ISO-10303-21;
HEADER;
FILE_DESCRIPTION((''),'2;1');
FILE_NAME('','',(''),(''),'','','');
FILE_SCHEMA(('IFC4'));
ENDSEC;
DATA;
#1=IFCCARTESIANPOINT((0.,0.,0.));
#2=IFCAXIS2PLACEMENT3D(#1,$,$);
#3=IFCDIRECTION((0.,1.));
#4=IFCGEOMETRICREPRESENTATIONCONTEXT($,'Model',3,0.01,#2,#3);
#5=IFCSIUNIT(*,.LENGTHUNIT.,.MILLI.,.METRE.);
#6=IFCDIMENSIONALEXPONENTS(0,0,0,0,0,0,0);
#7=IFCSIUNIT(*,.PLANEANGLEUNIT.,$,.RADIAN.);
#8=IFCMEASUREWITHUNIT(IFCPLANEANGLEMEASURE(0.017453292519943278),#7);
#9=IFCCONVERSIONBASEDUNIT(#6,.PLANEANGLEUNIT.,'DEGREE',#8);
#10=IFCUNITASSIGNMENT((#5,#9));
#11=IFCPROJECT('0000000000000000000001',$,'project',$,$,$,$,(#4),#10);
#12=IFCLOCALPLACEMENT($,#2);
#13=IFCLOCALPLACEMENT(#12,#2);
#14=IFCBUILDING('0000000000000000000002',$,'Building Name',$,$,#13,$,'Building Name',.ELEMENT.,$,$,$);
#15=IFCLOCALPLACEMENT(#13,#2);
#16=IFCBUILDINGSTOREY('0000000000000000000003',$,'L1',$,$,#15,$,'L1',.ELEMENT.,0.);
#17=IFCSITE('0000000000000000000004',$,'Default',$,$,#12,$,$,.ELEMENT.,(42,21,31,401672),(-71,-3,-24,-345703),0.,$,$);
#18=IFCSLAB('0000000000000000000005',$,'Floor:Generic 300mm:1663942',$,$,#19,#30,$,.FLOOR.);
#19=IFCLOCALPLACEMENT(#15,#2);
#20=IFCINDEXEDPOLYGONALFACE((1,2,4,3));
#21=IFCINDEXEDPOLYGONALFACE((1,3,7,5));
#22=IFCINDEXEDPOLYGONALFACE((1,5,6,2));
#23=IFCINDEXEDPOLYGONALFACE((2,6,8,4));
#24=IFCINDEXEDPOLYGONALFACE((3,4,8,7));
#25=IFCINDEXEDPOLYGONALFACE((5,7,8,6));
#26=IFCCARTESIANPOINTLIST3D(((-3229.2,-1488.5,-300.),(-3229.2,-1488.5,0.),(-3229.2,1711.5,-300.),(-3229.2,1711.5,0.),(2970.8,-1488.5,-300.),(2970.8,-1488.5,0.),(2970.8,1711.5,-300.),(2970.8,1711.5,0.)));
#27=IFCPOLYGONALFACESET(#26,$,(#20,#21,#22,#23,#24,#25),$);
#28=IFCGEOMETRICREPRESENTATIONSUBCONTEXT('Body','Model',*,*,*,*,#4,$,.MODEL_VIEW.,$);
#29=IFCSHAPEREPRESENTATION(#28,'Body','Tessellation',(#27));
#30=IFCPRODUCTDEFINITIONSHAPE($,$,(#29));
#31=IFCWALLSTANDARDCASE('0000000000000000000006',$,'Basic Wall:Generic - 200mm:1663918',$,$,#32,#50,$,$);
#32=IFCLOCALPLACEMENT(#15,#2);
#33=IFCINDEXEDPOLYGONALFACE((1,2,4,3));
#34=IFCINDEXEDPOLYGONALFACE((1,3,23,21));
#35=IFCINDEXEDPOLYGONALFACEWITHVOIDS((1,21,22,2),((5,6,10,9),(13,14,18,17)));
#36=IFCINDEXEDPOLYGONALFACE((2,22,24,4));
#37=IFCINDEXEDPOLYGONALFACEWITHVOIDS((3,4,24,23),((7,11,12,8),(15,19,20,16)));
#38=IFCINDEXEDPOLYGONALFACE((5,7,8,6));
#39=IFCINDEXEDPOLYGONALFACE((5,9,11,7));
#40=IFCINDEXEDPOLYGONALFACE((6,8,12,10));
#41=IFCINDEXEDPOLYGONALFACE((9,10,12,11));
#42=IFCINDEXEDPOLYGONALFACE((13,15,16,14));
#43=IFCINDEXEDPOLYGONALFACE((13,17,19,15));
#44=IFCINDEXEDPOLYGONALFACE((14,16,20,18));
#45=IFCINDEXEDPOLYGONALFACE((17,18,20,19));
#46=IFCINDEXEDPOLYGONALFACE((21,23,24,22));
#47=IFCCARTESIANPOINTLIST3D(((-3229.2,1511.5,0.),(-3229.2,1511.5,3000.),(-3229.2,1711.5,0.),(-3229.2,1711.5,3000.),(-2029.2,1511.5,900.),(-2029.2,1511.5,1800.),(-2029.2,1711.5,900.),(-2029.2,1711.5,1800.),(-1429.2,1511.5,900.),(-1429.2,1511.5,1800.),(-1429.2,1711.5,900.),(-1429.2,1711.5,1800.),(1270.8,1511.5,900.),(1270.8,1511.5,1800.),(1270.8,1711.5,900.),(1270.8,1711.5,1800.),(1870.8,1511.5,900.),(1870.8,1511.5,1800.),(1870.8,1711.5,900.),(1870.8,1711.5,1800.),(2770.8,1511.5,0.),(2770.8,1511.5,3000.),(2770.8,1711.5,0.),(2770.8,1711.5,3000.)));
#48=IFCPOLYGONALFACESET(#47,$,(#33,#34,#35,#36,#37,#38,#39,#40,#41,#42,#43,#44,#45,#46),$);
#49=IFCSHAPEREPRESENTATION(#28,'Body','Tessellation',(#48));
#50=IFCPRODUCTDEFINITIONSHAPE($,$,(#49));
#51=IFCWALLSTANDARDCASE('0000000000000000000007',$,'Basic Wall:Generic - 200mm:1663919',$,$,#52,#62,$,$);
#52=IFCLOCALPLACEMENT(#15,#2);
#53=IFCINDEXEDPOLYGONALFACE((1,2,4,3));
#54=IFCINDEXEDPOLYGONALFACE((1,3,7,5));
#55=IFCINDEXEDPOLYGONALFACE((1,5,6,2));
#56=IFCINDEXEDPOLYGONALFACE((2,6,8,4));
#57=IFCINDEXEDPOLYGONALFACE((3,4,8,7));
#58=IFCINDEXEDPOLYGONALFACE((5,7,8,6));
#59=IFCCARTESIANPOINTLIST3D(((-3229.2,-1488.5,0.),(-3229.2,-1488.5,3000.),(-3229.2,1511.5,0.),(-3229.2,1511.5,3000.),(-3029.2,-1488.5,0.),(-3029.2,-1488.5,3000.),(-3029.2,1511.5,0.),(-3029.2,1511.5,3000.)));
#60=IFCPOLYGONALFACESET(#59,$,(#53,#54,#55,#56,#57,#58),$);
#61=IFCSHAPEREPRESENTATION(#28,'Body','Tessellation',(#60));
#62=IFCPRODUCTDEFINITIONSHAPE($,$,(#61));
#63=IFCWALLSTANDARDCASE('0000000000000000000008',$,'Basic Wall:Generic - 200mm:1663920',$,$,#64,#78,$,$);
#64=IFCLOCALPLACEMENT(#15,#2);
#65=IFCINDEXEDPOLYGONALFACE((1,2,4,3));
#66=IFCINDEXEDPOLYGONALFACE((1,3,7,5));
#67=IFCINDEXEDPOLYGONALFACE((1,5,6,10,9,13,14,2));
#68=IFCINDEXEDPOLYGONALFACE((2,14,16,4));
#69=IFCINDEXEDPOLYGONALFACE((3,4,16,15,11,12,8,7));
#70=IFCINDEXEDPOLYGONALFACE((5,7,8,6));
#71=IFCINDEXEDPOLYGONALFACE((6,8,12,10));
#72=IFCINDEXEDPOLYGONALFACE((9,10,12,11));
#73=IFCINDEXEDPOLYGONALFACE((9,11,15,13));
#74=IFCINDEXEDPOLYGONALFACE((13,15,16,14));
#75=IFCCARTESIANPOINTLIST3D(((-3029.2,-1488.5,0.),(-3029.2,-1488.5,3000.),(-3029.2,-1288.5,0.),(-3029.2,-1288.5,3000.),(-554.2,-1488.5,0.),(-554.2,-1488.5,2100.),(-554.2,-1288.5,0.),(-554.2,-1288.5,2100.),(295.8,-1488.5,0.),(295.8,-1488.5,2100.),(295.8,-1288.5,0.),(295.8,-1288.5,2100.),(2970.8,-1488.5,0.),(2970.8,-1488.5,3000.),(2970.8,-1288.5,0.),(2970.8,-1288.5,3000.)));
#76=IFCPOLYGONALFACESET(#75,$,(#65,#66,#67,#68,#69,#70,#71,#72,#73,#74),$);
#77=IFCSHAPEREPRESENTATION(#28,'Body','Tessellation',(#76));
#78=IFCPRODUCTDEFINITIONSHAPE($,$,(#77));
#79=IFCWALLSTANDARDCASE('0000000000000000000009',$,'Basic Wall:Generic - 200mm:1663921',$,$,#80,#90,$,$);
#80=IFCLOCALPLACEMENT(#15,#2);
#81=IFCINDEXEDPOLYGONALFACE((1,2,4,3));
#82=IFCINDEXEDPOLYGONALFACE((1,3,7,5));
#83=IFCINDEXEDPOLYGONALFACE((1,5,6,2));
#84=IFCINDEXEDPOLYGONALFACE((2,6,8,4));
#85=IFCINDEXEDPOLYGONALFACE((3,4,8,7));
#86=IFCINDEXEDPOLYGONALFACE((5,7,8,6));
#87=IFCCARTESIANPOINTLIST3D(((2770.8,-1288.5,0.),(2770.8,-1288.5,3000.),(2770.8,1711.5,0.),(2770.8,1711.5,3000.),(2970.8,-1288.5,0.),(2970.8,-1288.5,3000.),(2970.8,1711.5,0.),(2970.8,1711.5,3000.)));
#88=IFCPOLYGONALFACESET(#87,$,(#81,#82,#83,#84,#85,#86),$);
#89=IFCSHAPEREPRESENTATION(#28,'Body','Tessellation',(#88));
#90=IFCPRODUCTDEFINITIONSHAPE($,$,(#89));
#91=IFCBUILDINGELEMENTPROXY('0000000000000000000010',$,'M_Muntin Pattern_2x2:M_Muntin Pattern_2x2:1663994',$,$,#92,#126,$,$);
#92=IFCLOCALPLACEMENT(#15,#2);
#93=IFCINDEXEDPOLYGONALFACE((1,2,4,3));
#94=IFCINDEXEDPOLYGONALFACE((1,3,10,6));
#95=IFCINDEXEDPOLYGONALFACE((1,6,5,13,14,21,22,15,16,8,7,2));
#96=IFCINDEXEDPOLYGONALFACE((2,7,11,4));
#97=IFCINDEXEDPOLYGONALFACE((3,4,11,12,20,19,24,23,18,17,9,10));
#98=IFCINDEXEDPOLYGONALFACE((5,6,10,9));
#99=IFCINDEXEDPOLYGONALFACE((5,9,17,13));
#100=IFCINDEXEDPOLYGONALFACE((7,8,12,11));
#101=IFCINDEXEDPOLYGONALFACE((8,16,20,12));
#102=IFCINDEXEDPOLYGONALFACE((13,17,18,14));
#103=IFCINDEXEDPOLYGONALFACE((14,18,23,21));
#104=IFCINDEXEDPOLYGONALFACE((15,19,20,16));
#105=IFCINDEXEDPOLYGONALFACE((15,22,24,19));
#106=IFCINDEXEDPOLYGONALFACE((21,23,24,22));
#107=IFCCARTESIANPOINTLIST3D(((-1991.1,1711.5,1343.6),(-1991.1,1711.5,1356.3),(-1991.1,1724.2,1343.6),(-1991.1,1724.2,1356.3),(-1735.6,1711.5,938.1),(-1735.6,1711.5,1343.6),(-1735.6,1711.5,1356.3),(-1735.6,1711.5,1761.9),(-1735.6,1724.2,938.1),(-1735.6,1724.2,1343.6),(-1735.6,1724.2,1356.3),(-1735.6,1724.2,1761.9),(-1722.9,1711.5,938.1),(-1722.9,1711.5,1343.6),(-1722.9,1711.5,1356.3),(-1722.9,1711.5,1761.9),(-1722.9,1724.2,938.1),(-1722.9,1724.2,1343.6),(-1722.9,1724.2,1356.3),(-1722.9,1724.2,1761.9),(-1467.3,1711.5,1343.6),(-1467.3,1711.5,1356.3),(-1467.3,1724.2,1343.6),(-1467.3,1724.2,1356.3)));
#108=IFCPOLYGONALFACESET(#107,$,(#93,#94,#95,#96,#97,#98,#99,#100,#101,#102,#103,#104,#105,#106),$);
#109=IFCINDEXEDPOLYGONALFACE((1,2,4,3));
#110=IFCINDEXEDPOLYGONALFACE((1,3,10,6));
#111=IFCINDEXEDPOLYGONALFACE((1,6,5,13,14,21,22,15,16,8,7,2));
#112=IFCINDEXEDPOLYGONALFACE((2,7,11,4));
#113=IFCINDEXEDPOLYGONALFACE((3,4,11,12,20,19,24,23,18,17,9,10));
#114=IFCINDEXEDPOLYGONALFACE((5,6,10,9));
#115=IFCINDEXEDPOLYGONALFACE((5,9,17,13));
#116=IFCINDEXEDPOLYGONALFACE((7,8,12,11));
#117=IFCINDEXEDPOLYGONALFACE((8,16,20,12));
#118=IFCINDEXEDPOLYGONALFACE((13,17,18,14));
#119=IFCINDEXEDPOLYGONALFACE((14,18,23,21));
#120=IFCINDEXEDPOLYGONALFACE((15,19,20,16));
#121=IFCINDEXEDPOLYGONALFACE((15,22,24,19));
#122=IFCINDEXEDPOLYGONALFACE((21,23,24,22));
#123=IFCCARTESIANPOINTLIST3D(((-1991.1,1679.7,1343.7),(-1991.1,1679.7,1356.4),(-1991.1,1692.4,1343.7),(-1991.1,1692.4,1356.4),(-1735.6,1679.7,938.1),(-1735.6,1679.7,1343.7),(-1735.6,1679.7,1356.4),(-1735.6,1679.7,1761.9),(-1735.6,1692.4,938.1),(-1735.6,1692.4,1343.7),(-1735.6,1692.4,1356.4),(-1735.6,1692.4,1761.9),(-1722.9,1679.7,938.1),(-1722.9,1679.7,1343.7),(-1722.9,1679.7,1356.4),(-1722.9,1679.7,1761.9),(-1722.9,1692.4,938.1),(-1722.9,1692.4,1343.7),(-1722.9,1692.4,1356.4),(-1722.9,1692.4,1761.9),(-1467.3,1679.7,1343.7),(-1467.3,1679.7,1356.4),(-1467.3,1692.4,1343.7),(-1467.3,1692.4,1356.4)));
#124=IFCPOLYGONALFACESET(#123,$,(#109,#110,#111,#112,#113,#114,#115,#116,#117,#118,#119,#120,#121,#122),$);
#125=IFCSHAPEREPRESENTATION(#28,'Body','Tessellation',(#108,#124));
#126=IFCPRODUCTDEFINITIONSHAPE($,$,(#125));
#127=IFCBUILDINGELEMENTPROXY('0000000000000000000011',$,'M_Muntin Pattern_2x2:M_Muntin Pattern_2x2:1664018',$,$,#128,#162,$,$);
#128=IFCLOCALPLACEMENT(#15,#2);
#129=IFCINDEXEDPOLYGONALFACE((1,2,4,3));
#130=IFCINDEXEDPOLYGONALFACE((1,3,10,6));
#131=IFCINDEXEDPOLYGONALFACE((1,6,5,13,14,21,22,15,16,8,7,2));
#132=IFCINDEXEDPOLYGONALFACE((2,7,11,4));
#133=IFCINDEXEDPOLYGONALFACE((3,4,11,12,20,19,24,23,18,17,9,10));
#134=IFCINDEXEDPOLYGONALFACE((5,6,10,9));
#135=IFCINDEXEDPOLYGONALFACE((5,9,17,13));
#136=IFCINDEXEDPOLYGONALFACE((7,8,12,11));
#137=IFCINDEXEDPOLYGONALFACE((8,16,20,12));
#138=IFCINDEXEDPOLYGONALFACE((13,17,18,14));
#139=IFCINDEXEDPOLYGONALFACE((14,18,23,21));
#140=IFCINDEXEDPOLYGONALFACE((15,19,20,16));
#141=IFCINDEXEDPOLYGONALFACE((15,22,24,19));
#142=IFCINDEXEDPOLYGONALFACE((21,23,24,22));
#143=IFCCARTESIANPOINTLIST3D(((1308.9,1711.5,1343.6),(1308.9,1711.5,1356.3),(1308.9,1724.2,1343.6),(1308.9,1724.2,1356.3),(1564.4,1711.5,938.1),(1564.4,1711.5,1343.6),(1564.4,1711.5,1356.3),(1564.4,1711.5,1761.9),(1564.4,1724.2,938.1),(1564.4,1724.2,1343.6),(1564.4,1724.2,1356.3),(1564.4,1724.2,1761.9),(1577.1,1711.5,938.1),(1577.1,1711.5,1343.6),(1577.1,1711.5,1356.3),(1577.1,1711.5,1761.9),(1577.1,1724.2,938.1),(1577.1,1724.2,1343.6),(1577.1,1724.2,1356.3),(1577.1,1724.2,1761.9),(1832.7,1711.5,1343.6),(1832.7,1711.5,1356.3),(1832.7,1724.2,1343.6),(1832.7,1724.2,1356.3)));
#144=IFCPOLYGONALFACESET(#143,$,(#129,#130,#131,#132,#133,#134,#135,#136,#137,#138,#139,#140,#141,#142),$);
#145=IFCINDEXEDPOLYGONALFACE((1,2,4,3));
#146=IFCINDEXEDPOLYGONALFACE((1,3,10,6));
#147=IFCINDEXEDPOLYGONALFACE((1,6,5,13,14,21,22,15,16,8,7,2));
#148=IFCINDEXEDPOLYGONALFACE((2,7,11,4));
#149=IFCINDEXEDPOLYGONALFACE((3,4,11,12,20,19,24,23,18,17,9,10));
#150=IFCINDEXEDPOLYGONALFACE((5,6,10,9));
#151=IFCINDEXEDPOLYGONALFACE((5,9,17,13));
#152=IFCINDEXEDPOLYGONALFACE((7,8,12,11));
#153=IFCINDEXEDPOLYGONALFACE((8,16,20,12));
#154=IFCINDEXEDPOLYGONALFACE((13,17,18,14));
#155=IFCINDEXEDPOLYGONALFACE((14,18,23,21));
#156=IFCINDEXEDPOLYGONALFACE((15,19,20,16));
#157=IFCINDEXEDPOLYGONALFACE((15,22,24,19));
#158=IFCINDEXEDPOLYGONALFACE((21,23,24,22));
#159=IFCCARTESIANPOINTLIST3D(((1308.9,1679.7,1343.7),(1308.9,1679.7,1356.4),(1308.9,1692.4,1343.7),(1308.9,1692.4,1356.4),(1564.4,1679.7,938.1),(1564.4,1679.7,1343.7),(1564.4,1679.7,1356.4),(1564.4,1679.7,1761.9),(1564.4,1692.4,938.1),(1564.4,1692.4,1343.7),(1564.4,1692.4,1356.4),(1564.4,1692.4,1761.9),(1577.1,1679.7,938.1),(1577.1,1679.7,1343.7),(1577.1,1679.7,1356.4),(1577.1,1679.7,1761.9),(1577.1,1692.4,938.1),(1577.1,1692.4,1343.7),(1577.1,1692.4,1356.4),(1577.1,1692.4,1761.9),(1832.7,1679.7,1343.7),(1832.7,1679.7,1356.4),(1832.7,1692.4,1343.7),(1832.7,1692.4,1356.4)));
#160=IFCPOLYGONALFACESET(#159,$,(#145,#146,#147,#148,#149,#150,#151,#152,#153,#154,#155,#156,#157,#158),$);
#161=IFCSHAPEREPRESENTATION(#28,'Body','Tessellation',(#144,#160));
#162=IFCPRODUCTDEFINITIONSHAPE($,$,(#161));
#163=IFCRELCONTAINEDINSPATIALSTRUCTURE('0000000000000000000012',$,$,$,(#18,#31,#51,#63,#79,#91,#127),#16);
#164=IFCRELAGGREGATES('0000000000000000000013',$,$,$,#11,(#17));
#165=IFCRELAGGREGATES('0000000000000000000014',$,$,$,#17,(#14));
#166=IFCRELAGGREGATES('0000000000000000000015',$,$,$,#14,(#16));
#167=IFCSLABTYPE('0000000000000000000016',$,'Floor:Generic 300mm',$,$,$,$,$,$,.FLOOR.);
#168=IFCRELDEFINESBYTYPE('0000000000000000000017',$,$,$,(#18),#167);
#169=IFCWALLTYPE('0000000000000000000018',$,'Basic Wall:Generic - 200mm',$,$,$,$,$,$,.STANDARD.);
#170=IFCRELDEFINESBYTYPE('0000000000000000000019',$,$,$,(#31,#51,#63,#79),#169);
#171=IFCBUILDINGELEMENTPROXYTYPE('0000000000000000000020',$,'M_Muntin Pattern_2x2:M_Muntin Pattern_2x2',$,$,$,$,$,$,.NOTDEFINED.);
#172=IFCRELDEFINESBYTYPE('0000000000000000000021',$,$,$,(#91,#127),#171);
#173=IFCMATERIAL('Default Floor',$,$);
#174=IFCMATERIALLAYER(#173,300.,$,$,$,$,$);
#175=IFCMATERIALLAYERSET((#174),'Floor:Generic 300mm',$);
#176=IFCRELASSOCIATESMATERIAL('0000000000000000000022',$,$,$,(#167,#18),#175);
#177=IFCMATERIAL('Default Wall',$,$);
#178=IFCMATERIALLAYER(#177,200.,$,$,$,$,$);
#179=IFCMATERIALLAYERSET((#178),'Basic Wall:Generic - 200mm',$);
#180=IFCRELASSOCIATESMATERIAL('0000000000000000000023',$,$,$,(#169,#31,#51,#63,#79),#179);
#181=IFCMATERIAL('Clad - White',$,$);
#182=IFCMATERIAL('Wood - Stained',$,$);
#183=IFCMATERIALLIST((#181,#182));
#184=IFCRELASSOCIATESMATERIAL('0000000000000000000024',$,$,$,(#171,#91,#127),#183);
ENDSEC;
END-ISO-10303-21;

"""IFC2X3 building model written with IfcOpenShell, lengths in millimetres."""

from ifc_helpers import new_model, entity, si_unit, converted_unit, direction, frame, frame_2d, origin, origin_2d_with_axis, place, context, subcontext, project, spatial, polyline, rectangle, outline, extrude, source, transform, mapped, material, material_list, layer, layer_set, layer_usage, type_object, type_shapes, element, save


model = new_model("IFC2X3")

# Units and contexts
model_context = context("Model", 3, precision=0.01, world=origin(), true_north=direction((0.0, 1.0)))
body_context = subcontext(model_context, "Body", "Model", "MODEL_VIEW")
ifc_project = project(units=[si_unit("LENGTHUNIT", "METRE", prefix="MILLI"), converted_unit("PLANEANGLEUNIT", "DEGREE", entity("IfcPlaneAngleMeasure", 0.017453292519943278), si_unit("PLANEANGLEUNIT", "RADIAN"), dimensions=[0, 0, 0, 0, 0, 0, 0])], contexts=[model_context])

# Site, building, storey
site_placement = place(None, origin())
site = spatial("IfcSite", under=ifc_project, at=site_placement, Name="Default", CompositionType="ELEMENT", RefLatitude=(42, 21, 31, 401672), RefLongitude=(-71, -3, -24, -345703), RefElevation=0.0)
building_placement = place(site_placement, origin())
building = spatial("IfcBuilding", under=site, at=building_placement, Name="Building Name", LongName="Building Name", CompositionType="ELEMENT")
storey_placement = place(building_placement, origin())
storey = spatial("IfcBuildingStorey", under=building, at=storey_placement, Name="L1", LongName="L1", CompositionType="ELEMENT", Elevation=0.0)

# Slab
ifc_material_1 = material(Name="Default Floor")
ifc_layer_1 = layer(ifc_material_1, 300.0)
ifc_layer_set_1 = layer_set([ifc_layer_1], Name="Floor:Generic 300mm")
ifc_layer_usage_1 = layer_usage(ifc_layer_set_1, "AXIS3", "POSITIVE", 0.0)
slab_type = type_object("IfcSlabType", Name="Floor:Generic 300mm", PredefinedType="FLOOR", material=ifc_layer_set_1)
slab_placement = place(storey_placement, origin())
element("IfcSlab", 1, at=slab_placement, inside=storey, type_object=slab_type, material=ifc_layer_usage_1, Name="Floor:Generic 300mm:1663942", PredefinedType="FLOOR", context=body_context, shape_type="SweptSolid", body=[
    extrude(rectangle(XDim=3200.0, YDim=6200.0, at=origin_2d_with_axis()), frame((-129.2, 111.5, 0.0), z_axis=(0.0, 0.0, -1.0), x_axis=(0.0, 1.0, 0.0)), (0.0, 0.0, 1.0), 300.0),
])

# Wall, openings
ifc_material_2 = material(Name="Default Wall")
ifc_layer_2 = layer(ifc_material_2, 200.0)
ifc_layer_set_2 = layer_set([ifc_layer_2], Name="Basic Wall:Generic - 200mm")
ifc_layer_usage_2 = layer_usage(ifc_layer_set_2, "AXIS2", "NEGATIVE", 100.0)
wall_type = type_object("IfcWallType", Name="Basic Wall:Generic - 200mm", PredefinedType="STANDARD", material=ifc_layer_set_2)
wall_1_placement = place(storey_placement, frame((-3229.2, 1611.5, 0.0)))
wall_1 = element("IfcWallStandardCase", 2, at=wall_1_placement, inside=storey, type_object=wall_type, material=ifc_layer_usage_2, Name="Basic Wall:Generic - 200mm:1663918", context=body_context, shape_type="SweptSolid", body=[
    extrude(rectangle(XDim=6000.0, YDim=200.0, at=frame_2d((3000.0, 0.0), x_axis=(-1.0, 0.0))), origin(), (0.0, 0.0, 1.0), 3000.0),
])
opening_1_placement = place(wall_1_placement, frame((1200.0, -100.0, 900.0)))
element("IfcOpeningElement", 3, at=opening_1_placement, cuts=wall_1, ObjectType="Opening", context=body_context, shape_type="SweptSolid", body=[
    extrude(rectangle(XDim=900.0, YDim=600.0, at=frame_2d((450.0, 300.0), x_axis=(-1.0, 0.0))), frame((0.0, 0.0, 0.0), z_axis=(0.0, 1.0, 0.0), x_axis=(0.0, 0.0, 1.0)), (0.0, 0.0, 1.0), 200.0),
])
opening_2_placement = place(wall_1_placement, frame((4500.0, -100.0, 900.0)))
element("IfcOpeningElement", 4, at=opening_2_placement, cuts=wall_1, ObjectType="Opening", context=body_context, shape_type="SweptSolid", body=[
    extrude(rectangle(XDim=900.0, YDim=600.0, at=frame_2d((450.0, 300.0), x_axis=(-1.0, 0.0))), frame((0.0, 0.0, 0.0), z_axis=(0.0, 1.0, 0.0), x_axis=(0.0, 0.0, 1.0)), (0.0, 0.0, 1.0), 200.0),
])

# Wall
ifc_layer_usage_3 = layer_usage(ifc_layer_set_2, "AXIS2", "NEGATIVE", 100.0)
wall_2_placement = place(storey_placement, frame((-3129.2, -1488.5, 0.0), z_axis=(0.0, 0.0, 1.0), x_axis=(0.0, 1.0, 0.0)))
element("IfcWallStandardCase", 5, at=wall_2_placement, inside=storey, type_object=wall_type, material=ifc_layer_usage_3, Name="Basic Wall:Generic - 200mm:1663919", context=body_context, shape_type="SweptSolid", body=[
    extrude(rectangle(XDim=3000.0, YDim=200.0, at=frame_2d((1500.0, 0.0), x_axis=(-1.0, 0.0))), origin(), (0.0, 0.0, 1.0), 3000.0),
])

# Wall, opening
ifc_layer_usage_4 = layer_usage(ifc_layer_set_2, "AXIS2", "NEGATIVE", 100.0)
wall_3_placement = place(storey_placement, frame((2970.8, -1388.5, 0.0), z_axis=(0.0, 0.0, 1.0), x_axis=(-1.0, 0.0, 0.0)))
wall_3 = element("IfcWallStandardCase", 6, at=wall_3_placement, inside=storey, type_object=wall_type, material=ifc_layer_usage_4, Name="Basic Wall:Generic - 200mm:1663920", context=body_context, shape_type="SweptSolid", body=[
    extrude(rectangle(XDim=6000.0, YDim=200.0, at=frame_2d((3000.0, 0.0), x_axis=(1.0, 0.0))), origin(), (0.0, 0.0, 1.0), 3000.0),
])
opening_3_placement = place(wall_3_placement, frame((2675.0, -100.0, 0.0)))
element("IfcOpeningElement", 7, at=opening_3_placement, cuts=wall_3, ObjectType="Opening", context=body_context, shape_type="SweptSolid", body=[
    extrude(rectangle(XDim=2100.0, YDim=850.0, at=frame_2d((1050.0, 425.0), x_axis=(1.0, 0.0))), frame((0.0, 0.0, 0.0), z_axis=(0.0, 1.0, 0.0), x_axis=(0.0, 0.0, 1.0)), (0.0, 0.0, 1.0), 200.0),
])

# Wall
ifc_layer_usage_5 = layer_usage(ifc_layer_set_2, "AXIS2", "NEGATIVE", 100.0)
wall_4_placement = place(storey_placement, frame((2870.8, 1711.5, 0.0), z_axis=(0.0, 0.0, 1.0), x_axis=(0.0, -1.0, 0.0)))
element("IfcWallStandardCase", 8, at=wall_4_placement, inside=storey, type_object=wall_type, material=ifc_layer_usage_5, Name="Basic Wall:Generic - 200mm:1663921", context=body_context, shape_type="SweptSolid", body=[
    extrude(rectangle(XDim=3000.0, YDim=200.0, at=frame_2d((1500.0, 0.0), x_axis=(-1.0, 0.0))), origin(), (0.0, 0.0, 1.0), 3000.0),
])

# Building element proxies
ifc_material_3 = material(Name="Clad - White")
ifc_material_4 = material(Name="Wood - Stained")
ifc_material_list = material_list([ifc_material_3, ifc_material_4])
building_element_proxy_type_1 = type_object("IfcBuildingElementProxyType", Name="M_Muntin Pattern_2x2:M_Muntin Pattern_2x2", PredefinedType="NOTDEFINED", material=ifc_material_list)
shared_shape_1 = source(origin(), body_context, "Body", "SweptSolid", [
    extrude(outline(polyline([(6.4, -6.4), (411.9, -6.4), (411.9, 6.3), (6.4, 6.3), (6.4, 261.9), (-6.3, 261.9), (-6.3, 6.3), (-411.9, 6.3), (-411.9, -6.4), (-6.3, -6.4), (-6.3, -261.9), (6.4, -261.9), (6.4, -6.4)])), frame((0.0, -22.2, 411.9), z_axis=(0.0, 1.0, 0.0), x_axis=(0.0, 0.0, 1.0)), (0.0, 0.0, 1.0), 12.7),
    extrude(outline(polyline([(6.4, -6.4), (411.9, -6.4), (411.9, 6.3), (6.4, 6.3), (6.4, 261.9), (-6.3, 261.9), (-6.3, 6.3), (-411.9, 6.3), (-411.9, -6.4), (-6.3, -6.4), (-6.3, -261.9), (6.4, -261.9), (6.4, -6.4)])), frame((0.0, 9.5, 411.9), z_axis=(0.0, 1.0, 0.0), x_axis=(0.0, 0.0, 1.0)), (0.0, 0.0, 1.0), 12.7),
])
type_shapes(building_element_proxy_type_1, [shared_shape_1])
for number, where, z_axis, x_axis, name in (
    (9, (-1729.2, 1701.9, 938.1), (0.0, 0.0, 1.0), (-1.0, 0.0, 0.0), "M_Muntin Pattern_2x2:M_Muntin Pattern_2x2:1663994"),
    (10, (1570.8, 1701.9, 938.1), (0.0, 0.0, 1.0), (-1.0, 0.0, 0.0), "M_Muntin Pattern_2x2:M_Muntin Pattern_2x2:1664018"),
):
    element("IfcBuildingElementProxy", number, at=place(storey_placement, frame(where, z_axis=z_axis, x_axis=x_axis)), inside=storey, type_object=building_element_proxy_type_1, material=ifc_material_list, Name=name, context=body_context, shape_type="MappedRepresentation", body=[
        mapped(shared_shape_1, transform((0.0, 0.0, 0.0), scale=1.0)),
    ])

save(model, "model.ifc")
